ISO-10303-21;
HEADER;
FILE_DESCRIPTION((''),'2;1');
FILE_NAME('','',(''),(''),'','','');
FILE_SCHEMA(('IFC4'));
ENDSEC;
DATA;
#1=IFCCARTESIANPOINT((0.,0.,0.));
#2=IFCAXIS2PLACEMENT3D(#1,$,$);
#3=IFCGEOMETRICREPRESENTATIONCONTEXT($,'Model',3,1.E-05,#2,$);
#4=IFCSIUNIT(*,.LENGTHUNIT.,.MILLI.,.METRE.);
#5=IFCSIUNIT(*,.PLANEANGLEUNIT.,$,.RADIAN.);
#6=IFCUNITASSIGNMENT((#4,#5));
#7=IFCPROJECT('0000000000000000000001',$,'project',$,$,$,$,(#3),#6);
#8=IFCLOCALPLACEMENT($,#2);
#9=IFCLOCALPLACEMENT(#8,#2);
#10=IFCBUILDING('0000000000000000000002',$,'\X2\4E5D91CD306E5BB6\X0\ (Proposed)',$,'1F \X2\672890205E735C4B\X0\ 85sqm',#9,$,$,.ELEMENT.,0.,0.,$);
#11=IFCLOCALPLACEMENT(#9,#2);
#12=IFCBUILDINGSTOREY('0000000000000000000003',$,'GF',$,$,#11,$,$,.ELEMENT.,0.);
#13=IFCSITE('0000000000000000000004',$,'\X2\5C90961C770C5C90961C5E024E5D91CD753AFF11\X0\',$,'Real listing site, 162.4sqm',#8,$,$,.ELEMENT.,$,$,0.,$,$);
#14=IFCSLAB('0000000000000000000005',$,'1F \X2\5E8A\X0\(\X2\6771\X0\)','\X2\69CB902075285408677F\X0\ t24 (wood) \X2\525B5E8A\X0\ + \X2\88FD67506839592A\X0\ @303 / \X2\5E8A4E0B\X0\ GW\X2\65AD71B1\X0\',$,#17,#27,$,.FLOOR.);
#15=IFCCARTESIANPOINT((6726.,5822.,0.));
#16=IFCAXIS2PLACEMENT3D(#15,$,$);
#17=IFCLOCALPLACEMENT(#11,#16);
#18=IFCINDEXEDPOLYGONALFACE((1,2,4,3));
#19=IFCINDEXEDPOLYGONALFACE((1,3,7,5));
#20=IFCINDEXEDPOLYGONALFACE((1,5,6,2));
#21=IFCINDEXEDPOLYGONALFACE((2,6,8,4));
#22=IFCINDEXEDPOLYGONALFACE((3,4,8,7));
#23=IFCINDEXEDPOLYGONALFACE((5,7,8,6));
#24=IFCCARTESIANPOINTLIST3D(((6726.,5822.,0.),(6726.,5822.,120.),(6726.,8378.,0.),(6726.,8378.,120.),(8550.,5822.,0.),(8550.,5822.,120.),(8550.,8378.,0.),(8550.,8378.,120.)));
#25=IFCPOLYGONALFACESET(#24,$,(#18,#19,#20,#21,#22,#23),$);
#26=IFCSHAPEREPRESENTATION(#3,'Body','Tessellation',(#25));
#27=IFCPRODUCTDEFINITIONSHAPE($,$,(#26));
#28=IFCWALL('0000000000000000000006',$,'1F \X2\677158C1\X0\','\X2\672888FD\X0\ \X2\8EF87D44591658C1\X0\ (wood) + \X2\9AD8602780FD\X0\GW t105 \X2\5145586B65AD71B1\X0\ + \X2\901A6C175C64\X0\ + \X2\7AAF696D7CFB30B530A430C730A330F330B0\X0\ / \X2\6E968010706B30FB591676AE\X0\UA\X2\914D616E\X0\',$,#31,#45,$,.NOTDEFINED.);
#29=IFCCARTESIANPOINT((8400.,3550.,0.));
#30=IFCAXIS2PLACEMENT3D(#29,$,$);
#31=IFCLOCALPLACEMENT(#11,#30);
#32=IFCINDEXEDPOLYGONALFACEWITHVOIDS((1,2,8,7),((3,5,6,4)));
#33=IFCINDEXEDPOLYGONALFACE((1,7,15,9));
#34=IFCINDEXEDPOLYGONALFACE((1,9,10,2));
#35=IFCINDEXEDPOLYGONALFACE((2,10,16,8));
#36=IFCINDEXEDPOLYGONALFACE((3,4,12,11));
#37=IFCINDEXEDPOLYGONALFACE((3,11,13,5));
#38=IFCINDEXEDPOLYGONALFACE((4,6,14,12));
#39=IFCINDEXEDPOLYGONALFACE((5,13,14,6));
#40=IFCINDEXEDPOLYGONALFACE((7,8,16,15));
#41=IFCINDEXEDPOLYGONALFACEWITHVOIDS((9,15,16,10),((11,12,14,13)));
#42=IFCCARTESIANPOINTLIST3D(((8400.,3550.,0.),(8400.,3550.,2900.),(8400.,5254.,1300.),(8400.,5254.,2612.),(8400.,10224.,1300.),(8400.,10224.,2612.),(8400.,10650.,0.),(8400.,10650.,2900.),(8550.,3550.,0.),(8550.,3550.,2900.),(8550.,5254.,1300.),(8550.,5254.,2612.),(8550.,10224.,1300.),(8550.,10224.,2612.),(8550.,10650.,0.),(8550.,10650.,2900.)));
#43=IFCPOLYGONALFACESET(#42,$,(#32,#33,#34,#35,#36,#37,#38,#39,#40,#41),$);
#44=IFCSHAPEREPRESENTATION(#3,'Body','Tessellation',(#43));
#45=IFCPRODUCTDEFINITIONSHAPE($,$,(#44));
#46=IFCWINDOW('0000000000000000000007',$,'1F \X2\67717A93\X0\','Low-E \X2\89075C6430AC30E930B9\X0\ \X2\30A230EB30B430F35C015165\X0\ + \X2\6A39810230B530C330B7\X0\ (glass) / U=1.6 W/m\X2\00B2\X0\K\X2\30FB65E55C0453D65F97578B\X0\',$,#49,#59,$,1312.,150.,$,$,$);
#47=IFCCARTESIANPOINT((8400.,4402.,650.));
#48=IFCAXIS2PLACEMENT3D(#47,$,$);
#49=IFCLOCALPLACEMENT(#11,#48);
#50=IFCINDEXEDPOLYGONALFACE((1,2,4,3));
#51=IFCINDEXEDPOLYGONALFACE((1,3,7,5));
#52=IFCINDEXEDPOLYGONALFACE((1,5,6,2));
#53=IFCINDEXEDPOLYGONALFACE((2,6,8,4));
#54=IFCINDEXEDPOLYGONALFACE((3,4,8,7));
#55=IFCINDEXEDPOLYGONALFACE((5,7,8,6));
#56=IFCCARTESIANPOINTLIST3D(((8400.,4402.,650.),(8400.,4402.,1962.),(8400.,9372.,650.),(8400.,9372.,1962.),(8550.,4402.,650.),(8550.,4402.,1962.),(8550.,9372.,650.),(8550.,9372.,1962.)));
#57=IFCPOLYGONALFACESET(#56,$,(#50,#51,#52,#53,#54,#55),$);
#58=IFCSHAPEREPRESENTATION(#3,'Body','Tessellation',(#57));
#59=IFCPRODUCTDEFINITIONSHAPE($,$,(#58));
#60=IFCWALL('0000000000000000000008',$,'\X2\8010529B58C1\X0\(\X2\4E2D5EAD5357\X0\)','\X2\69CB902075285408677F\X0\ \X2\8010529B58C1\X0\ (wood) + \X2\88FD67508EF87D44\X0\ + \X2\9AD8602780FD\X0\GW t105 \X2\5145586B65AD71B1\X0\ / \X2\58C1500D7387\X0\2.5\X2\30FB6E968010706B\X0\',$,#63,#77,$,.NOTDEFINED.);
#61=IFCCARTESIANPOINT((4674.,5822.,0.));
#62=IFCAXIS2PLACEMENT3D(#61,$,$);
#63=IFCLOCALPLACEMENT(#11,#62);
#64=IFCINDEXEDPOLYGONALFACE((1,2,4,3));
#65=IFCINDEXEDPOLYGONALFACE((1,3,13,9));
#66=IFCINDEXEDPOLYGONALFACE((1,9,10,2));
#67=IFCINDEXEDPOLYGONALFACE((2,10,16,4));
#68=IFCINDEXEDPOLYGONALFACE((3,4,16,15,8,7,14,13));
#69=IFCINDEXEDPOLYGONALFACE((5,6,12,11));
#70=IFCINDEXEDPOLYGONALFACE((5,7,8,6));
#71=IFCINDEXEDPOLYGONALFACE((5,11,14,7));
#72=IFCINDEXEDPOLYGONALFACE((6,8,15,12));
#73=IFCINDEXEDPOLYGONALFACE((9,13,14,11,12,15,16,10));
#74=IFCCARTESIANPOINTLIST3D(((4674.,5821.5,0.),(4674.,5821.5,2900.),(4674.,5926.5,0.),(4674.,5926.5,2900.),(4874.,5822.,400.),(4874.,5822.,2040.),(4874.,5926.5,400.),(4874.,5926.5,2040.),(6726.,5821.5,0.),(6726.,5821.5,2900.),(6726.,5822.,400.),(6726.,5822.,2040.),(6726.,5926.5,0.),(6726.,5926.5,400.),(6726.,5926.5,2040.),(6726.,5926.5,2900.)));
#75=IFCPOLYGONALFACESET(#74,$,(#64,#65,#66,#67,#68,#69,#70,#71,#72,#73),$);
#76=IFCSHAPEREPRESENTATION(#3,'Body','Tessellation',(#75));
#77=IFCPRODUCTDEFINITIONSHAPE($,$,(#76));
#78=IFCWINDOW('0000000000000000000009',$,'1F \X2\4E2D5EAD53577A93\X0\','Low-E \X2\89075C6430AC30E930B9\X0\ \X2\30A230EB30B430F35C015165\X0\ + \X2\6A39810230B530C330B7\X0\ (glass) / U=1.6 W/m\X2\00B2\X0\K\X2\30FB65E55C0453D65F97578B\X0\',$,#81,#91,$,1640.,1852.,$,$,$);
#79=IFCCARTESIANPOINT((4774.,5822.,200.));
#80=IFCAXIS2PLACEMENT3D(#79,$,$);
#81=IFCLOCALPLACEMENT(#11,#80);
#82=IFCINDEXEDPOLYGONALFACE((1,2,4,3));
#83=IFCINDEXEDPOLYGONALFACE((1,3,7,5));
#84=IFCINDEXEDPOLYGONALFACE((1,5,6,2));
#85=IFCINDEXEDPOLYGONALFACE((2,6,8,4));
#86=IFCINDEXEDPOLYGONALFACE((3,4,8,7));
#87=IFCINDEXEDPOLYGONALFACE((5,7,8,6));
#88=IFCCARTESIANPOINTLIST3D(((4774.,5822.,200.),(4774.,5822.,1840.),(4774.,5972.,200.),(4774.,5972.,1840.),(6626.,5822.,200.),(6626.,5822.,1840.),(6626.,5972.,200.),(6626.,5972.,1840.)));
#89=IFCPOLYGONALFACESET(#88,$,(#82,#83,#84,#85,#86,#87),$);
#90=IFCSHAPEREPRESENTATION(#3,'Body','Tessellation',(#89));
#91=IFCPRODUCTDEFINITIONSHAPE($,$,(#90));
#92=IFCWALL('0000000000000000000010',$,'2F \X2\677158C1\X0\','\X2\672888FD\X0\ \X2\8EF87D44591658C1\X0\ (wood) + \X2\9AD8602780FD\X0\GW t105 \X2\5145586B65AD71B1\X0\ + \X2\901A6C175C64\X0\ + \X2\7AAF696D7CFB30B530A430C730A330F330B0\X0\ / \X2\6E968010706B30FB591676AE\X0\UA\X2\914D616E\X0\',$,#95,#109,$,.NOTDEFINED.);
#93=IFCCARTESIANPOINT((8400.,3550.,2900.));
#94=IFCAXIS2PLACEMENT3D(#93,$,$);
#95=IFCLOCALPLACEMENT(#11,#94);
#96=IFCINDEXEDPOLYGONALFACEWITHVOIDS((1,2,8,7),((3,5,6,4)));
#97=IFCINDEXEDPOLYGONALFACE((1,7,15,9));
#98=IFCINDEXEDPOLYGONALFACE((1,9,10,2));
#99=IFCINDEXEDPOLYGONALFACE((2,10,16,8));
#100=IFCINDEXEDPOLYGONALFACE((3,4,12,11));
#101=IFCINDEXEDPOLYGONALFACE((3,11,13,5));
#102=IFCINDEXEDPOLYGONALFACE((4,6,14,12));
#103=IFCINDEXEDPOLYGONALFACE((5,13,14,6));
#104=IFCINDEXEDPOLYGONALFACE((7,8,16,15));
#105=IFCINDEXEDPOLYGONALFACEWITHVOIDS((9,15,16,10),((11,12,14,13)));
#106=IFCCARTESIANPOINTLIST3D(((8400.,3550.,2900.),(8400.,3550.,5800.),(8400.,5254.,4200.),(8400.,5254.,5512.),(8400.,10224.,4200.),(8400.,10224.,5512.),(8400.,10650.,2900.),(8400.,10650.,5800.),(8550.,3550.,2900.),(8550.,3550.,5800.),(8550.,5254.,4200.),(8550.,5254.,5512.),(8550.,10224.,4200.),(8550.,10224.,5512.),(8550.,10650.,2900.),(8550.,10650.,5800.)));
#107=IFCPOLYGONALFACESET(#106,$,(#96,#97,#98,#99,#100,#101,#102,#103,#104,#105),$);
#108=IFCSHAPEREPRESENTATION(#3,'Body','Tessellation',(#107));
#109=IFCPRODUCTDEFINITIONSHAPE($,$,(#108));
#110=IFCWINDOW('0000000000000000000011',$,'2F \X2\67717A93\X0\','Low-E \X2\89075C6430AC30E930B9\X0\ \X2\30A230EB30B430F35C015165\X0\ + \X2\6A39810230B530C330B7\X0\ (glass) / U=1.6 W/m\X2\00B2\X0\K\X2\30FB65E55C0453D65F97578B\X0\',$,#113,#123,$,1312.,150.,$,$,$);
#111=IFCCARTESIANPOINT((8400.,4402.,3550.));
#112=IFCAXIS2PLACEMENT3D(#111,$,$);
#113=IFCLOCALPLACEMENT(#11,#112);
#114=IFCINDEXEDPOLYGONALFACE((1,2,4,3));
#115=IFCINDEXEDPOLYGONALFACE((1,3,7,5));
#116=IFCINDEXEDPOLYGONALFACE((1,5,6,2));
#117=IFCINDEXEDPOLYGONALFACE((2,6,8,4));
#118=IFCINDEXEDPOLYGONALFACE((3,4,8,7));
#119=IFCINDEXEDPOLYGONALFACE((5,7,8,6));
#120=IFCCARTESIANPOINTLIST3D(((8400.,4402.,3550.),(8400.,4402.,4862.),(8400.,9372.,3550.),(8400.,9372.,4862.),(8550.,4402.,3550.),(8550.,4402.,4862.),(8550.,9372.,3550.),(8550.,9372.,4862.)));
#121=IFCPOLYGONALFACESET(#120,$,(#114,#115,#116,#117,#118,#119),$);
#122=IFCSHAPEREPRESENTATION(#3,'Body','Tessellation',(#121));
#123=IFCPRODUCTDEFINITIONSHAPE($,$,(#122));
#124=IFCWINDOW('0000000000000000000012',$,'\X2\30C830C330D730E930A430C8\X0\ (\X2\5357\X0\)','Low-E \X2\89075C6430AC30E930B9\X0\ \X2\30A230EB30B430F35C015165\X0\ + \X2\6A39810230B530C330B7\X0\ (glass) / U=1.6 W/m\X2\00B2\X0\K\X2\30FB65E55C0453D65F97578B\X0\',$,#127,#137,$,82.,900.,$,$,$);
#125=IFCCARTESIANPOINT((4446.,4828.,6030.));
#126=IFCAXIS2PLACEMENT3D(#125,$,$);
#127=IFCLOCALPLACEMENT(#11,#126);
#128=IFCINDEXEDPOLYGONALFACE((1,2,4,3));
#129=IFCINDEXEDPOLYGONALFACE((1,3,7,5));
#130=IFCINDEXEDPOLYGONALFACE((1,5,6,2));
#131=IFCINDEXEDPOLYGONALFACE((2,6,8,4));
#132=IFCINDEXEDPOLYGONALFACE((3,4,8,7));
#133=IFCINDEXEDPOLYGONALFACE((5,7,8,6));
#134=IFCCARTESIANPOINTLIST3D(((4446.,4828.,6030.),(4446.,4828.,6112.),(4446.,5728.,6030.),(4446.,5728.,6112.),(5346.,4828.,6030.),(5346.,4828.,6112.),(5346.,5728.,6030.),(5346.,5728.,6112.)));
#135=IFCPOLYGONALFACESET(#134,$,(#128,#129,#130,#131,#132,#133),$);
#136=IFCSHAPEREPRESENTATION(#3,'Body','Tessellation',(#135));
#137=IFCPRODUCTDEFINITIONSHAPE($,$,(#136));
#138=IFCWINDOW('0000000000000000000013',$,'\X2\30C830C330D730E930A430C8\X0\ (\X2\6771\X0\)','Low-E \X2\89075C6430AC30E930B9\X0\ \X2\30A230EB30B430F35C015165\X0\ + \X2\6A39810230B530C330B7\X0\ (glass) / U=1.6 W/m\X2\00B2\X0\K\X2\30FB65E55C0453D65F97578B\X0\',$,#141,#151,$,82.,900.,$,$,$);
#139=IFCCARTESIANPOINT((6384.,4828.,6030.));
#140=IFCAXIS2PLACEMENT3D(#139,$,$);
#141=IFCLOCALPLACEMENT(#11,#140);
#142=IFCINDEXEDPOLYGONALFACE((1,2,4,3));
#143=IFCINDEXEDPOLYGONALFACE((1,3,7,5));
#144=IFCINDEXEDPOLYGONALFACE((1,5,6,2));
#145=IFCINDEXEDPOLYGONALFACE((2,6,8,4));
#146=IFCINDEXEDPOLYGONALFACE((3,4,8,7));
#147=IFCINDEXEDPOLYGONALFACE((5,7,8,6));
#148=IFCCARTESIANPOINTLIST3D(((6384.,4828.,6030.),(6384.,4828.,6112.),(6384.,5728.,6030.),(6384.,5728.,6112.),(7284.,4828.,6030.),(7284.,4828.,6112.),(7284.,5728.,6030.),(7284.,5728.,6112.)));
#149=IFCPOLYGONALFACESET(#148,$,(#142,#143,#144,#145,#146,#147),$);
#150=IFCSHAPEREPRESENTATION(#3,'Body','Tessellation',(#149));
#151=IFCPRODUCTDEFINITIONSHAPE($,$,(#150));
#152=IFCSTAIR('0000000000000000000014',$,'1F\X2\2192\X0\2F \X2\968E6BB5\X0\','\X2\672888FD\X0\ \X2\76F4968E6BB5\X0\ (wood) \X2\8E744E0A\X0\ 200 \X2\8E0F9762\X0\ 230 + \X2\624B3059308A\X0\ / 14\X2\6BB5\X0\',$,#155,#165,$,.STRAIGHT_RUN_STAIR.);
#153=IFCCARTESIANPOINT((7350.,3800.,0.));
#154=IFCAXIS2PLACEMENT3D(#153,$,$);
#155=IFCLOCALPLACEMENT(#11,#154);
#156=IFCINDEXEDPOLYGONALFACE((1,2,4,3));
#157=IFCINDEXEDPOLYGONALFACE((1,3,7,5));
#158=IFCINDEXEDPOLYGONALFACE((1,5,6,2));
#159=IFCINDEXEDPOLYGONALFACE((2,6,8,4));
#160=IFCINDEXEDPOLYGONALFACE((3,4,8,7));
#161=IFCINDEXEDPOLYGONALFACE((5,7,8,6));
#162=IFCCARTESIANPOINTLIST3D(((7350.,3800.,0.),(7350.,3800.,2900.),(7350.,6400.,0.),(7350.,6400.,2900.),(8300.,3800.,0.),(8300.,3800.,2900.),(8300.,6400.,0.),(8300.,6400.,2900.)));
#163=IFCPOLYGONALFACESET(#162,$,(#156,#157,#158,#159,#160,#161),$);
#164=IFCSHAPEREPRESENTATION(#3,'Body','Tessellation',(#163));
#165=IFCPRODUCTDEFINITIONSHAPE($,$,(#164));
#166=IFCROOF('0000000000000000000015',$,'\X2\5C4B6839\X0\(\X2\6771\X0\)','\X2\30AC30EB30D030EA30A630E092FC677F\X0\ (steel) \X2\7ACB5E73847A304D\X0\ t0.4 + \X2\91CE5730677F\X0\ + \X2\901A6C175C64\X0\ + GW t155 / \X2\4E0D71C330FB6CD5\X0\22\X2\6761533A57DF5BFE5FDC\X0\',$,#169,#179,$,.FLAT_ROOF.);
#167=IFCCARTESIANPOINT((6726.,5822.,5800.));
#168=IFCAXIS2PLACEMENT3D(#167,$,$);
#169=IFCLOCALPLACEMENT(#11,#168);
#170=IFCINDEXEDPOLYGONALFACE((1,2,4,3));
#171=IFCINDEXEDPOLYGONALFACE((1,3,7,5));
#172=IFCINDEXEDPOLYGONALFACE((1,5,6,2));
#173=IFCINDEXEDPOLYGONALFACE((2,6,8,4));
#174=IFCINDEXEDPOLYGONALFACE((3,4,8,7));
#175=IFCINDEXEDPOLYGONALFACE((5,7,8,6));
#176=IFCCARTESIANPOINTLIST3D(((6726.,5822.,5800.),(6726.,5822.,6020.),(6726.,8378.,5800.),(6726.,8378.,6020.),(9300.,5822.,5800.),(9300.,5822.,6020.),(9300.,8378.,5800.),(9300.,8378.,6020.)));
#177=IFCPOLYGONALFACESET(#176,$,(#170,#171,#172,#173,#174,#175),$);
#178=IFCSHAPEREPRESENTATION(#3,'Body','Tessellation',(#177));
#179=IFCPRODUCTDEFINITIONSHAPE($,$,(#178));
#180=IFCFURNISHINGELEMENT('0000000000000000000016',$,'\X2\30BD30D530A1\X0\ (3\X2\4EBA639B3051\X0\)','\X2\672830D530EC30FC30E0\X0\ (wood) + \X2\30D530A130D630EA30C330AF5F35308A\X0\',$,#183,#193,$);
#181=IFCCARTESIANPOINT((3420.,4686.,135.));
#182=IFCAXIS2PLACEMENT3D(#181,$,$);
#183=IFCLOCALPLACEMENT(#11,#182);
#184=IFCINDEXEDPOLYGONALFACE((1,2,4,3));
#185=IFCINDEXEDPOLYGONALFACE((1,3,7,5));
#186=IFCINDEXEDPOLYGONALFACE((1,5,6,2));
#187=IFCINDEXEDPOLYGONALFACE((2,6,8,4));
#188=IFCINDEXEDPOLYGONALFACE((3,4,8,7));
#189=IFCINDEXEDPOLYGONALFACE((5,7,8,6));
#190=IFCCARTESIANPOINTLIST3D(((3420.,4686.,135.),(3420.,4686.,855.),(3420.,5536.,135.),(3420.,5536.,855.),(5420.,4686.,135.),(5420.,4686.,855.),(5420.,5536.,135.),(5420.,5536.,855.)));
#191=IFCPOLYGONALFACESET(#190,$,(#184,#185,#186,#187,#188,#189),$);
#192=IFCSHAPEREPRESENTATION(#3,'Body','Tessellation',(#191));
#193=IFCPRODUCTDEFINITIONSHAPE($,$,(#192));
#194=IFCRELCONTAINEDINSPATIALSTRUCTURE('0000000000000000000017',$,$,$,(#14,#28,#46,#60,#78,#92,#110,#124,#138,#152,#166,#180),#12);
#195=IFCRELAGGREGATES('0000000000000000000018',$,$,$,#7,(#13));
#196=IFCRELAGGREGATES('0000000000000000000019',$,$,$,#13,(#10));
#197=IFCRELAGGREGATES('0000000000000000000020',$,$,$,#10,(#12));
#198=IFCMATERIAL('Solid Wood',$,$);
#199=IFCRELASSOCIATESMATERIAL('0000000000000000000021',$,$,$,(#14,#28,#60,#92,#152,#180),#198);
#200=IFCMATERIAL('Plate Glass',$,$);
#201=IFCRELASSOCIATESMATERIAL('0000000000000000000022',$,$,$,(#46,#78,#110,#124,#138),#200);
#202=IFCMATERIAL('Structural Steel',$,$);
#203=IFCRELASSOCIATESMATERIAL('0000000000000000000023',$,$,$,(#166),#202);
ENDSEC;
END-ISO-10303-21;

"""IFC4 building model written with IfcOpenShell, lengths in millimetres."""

from ifc_helpers import new_model, si_unit, frame, frame_2d, origin, place, context, project, spatial, rectangle, extrude, material, element, fill, save


model = new_model("IFC4")

# Units and contexts
model_context = context("Model", 3, precision=1e-05, world=origin())
ifc_project = project(units=[si_unit("LENGTHUNIT", "METRE", prefix="MILLI"), si_unit("PLANEANGLEUNIT", "RADIAN")], contexts=[model_context])

# Site, building, storey
site_placement = place(None, origin())
site = spatial("IfcSite", under=ifc_project, at=site_placement, Name="岐阜県岐阜市九重町１", ObjectType="Real listing site, 162.4sqm", CompositionType="ELEMENT", RefElevation=0.0)
building_placement = place(site_placement, origin())
building = spatial("IfcBuilding", under=site, at=building_placement, Name="九重の家 (Proposed)", ObjectType="1F 木造平屋 85sqm", CompositionType="ELEMENT", ElevationOfRefHeight=0.0, ElevationOfTerrain=0.0)
storey_placement = place(building_placement, origin())
storey = spatial("IfcBuildingStorey", under=building, at=storey_placement, Name="GF", CompositionType="ELEMENT", Elevation=0.0)

# Slab
ifc_material_1 = material(Name="Solid Wood")
slab_placement = place(storey_placement, frame((6726.0, 5822.0, 0.0)))
element("IfcSlab", 1, at=slab_placement, inside=storey, material=ifc_material_1, Name="1F 床(東)", Description="構造用合板 t24 (wood) 剛床 + 製材根太 @303 / 床下 GW断熱", PredefinedType="FLOOR", context=model_context, shape_type="SweptSolid", body=[
    extrude(rectangle(XDim=1824.0, YDim=2556.0, at=frame_2d((912.0, 1278.0))), frame((6726.0, 5822.0, 0.0)), (0.0, 0.0, 1.0), 120.0),
])

# Walls, openings, windows
wall_1_placement = place(storey_placement, frame((8400.0, 3550.0, 0.0)))
wall_1 = element("IfcWall", 2, at=wall_1_placement, inside=storey, material=ifc_material_1, Name="1F 東壁", Description="木製 軸組外壁 (wood) + 高性能GW t105 充填断熱 + 通気層 + 窯業系サイディング / 準耐火・外皮UA配慮", PredefinedType="NOTDEFINED", context=model_context, shape_type="SweptSolid", body=[
    extrude(rectangle(XDim=150.0, YDim=7100.0, at=frame_2d((75.0, 3550.0))), frame((8400.0, 3550.0, 0.0)), (0.0, 0.0, 1.0), 2900.0),
])
opening_1_placement = place(storey_placement, frame((8400.0, 4402.0, 650.0)))
opening_1 = element("IfcOpeningElement", 3, at=opening_1_placement, cuts=wall_1, PredefinedType="NOTDEFINED", context=model_context, shape_type="SweptSolid", body=[
    extrude(rectangle(XDim=150.0, YDim=4970.0, at=frame_2d((75.0, 2485.0))), frame((8400.0, 4402.0, 650.0)), (0.0, 0.0, 1.0), 1312.0),
])
ifc_material_2 = material(Name="Plate Glass")
window_1_placement = place(storey_placement, frame((8400.0, 4402.0, 650.0)))
window_1 = element("IfcWindow", 4, at=window_1_placement, inside=storey, material=ifc_material_2, Name="1F 東窓", Description="Low-E 複層ガラス アルゴン封入 + 樹脂サッシ (glass) / U=1.6 W/m²K・日射取得型", OverallHeight=1312.0, OverallWidth=150.0, context=model_context, shape_type="SweptSolid", body=[
    extrude(rectangle(XDim=150.0, YDim=4970.0, at=frame_2d((75.0, 2485.0))), frame((8400.0, 4402.0, 650.0)), (0.0, 0.0, 1.0), 1312.0),
])
fill(opening_1, window_1)
wall_2_placement = place(storey_placement, frame((4674.0, 5822.0, 0.0)))
wall_2 = element("IfcWall", 5, at=wall_2_placement, inside=storey, material=ifc_material_1, Name="耐力壁(中庭南)", Description="構造用合板 耐力壁 (wood) + 製材軸組 + 高性能GW t105 充填断熱 / 壁倍率2.5・準耐火", PredefinedType="NOTDEFINED", context=model_context, shape_type="SweptSolid", body=[
    extrude(rectangle(XDim=2052.0, YDim=105.0, at=frame_2d((1026.0, 52.0))), frame((4674.0, 5822.0, 0.0)), (0.0, 0.0, 1.0), 2900.0),
])
opening_2_placement = place(storey_placement, frame((4774.0, 5822.0, 200.0)))
opening_2 = element("IfcOpeningElement", 6, at=opening_2_placement, cuts=wall_2, PredefinedType="NOTDEFINED", context=model_context, shape_type="SweptSolid", body=[
    extrude(rectangle(XDim=1852.0, YDim=150.0, at=frame_2d((926.0, 75.0))), frame((4774.0, 5822.0, 200.0)), (0.0, 0.0, 1.0), 1640.0),
])
window_2_placement = place(storey_placement, frame((4774.0, 5822.0, 200.0)))
window_2 = element("IfcWindow", 7, at=window_2_placement, inside=storey, material=ifc_material_2, Name="1F 中庭南窓", Description="Low-E 複層ガラス アルゴン封入 + 樹脂サッシ (glass) / U=1.6 W/m²K・日射取得型", OverallHeight=1640.0, OverallWidth=1852.0, context=model_context, shape_type="SweptSolid", body=[
    extrude(rectangle(XDim=1852.0, YDim=150.0, at=frame_2d((926.0, 75.0))), frame((4774.0, 5822.0, 200.0)), (0.0, 0.0, 1.0), 1640.0),
])
fill(opening_2, window_2)

# Wall, opening, window
wall_3_placement = place(storey_placement, frame((8400.0, 3550.0, 2900.0)))
wall_3 = element("IfcWall", 8, at=wall_3_placement, inside=storey, material=ifc_material_1, Name="2F 東壁", Description="木製 軸組外壁 (wood) + 高性能GW t105 充填断熱 + 通気層 + 窯業系サイディング / 準耐火・外皮UA配慮", PredefinedType="NOTDEFINED", context=model_context, shape_type="SweptSolid", body=[
    extrude(rectangle(XDim=150.0, YDim=7100.0, at=frame_2d((75.0, 3550.0))), frame((8400.0, 3550.0, 2900.0)), (0.0, 0.0, 1.0), 2900.0),
])
opening_3_placement = place(storey_placement, frame((8400.0, 4402.0, 3550.0)))
opening_3 = element("IfcOpeningElement", 9, at=opening_3_placement, cuts=wall_3, PredefinedType="NOTDEFINED", context=model_context, shape_type="SweptSolid", body=[
    extrude(rectangle(XDim=150.0, YDim=4970.0, at=frame_2d((75.0, 2485.0))), frame((8400.0, 4402.0, 3550.0)), (0.0, 0.0, 1.0), 1312.0),
])
window_3_placement = place(storey_placement, frame((8400.0, 4402.0, 3550.0)))
window_3 = element("IfcWindow", 10, at=window_3_placement, inside=storey, material=ifc_material_2, Name="2F 東窓", Description="Low-E 複層ガラス アルゴン封入 + 樹脂サッシ (glass) / U=1.6 W/m²K・日射取得型", OverallHeight=1312.0, OverallWidth=150.0, context=model_context, shape_type="SweptSolid", body=[
    extrude(rectangle(XDim=150.0, YDim=4970.0, at=frame_2d((75.0, 2485.0))), frame((8400.0, 4402.0, 3550.0)), (0.0, 0.0, 1.0), 1312.0),
])
fill(opening_3, window_3)

# Windows
window_4_placement = place(storey_placement, frame((4446.0, 4828.0, 6030.0)))
element("IfcWindow", 11, at=window_4_placement, inside=storey, material=ifc_material_2, Name="トップライト (南)", Description="Low-E 複層ガラス アルゴン封入 + 樹脂サッシ (glass) / U=1.6 W/m²K・日射取得型", OverallHeight=82.0, OverallWidth=900.0, context=model_context, shape_type="SweptSolid", body=[
    extrude(rectangle(XDim=900.0, YDim=900.0, at=frame_2d((450.0, 450.0))), frame((4446.0, 4828.0, 6030.0)), (0.0, 0.0, 1.0), 82.0),
])
window_5_placement = place(storey_placement, frame((6384.0, 4828.0, 6030.0)))
element("IfcWindow", 12, at=window_5_placement, inside=storey, material=ifc_material_2, Name="トップライト (東)", Description="Low-E 複層ガラス アルゴン封入 + 樹脂サッシ (glass) / U=1.6 W/m²K・日射取得型", OverallHeight=82.0, OverallWidth=900.0, context=model_context, shape_type="SweptSolid", body=[
    extrude(rectangle(XDim=900.0, YDim=900.0, at=frame_2d((450.0, 450.0))), frame((6384.0, 4828.0, 6030.0)), (0.0, 0.0, 1.0), 82.0),
])

# Stair
stair_placement = place(storey_placement, frame((7350.0, 3800.0, 0.0)))
element("IfcStair", 13, at=stair_placement, inside=storey, material=ifc_material_1, Name="1F→2F 階段", Description="木製 直階段 (wood) 蹴上 200 踏面 230 + 手すり / 14段", PredefinedType="STRAIGHT_RUN_STAIR", context=model_context, shape_type="SweptSolid", body=[
    extrude(rectangle(XDim=950.0, YDim=2600.0, at=frame_2d((475.0, 1300.0))), frame((7350.0, 3800.0, 0.0)), (0.0, 0.0, 1.0), 2900.0),
])

# Roof
ifc_material_3 = material(Name="Structural Steel")
roof_placement = place(storey_placement, frame((6726.0, 5822.0, 5800.0)))
element("IfcRoof", 14, at=roof_placement, inside=storey, material=ifc_material_3, Name="屋根(東)", Description="ガルバリウム鋼板 (steel) 立平葺き t0.4 + 野地板 + 通気層 + GW t155 / 不燃・法22条区域対応", PredefinedType="FLAT_ROOF", context=model_context, shape_type="SweptSolid", body=[
    extrude(rectangle(XDim=2574.0, YDim=2556.0, at=frame_2d((1287.0, 1278.0))), frame((6726.0, 5822.0, 5800.0)), (0.0, 0.0, 1.0), 220.0),
])

# Furnishing element
furnishing_1_placement = place(storey_placement, frame((3420.0, 4686.0, 135.0)))
element("IfcFurnishingElement", 15, at=furnishing_1_placement, inside=storey, material=ifc_material_1, Name="ソファ (3人掛け)", Description="木フレーム (wood) + ファブリック張り", context=model_context, shape_type="SweptSolid", body=[
    extrude(rectangle(XDim=2000.0, YDim=850.0, at=frame_2d((1000.0, 425.0))), frame((3420.0, 4686.0, 135.0)), (0.0, 0.0, 1.0), 720.0),
])

save(model, "model.ifc")
